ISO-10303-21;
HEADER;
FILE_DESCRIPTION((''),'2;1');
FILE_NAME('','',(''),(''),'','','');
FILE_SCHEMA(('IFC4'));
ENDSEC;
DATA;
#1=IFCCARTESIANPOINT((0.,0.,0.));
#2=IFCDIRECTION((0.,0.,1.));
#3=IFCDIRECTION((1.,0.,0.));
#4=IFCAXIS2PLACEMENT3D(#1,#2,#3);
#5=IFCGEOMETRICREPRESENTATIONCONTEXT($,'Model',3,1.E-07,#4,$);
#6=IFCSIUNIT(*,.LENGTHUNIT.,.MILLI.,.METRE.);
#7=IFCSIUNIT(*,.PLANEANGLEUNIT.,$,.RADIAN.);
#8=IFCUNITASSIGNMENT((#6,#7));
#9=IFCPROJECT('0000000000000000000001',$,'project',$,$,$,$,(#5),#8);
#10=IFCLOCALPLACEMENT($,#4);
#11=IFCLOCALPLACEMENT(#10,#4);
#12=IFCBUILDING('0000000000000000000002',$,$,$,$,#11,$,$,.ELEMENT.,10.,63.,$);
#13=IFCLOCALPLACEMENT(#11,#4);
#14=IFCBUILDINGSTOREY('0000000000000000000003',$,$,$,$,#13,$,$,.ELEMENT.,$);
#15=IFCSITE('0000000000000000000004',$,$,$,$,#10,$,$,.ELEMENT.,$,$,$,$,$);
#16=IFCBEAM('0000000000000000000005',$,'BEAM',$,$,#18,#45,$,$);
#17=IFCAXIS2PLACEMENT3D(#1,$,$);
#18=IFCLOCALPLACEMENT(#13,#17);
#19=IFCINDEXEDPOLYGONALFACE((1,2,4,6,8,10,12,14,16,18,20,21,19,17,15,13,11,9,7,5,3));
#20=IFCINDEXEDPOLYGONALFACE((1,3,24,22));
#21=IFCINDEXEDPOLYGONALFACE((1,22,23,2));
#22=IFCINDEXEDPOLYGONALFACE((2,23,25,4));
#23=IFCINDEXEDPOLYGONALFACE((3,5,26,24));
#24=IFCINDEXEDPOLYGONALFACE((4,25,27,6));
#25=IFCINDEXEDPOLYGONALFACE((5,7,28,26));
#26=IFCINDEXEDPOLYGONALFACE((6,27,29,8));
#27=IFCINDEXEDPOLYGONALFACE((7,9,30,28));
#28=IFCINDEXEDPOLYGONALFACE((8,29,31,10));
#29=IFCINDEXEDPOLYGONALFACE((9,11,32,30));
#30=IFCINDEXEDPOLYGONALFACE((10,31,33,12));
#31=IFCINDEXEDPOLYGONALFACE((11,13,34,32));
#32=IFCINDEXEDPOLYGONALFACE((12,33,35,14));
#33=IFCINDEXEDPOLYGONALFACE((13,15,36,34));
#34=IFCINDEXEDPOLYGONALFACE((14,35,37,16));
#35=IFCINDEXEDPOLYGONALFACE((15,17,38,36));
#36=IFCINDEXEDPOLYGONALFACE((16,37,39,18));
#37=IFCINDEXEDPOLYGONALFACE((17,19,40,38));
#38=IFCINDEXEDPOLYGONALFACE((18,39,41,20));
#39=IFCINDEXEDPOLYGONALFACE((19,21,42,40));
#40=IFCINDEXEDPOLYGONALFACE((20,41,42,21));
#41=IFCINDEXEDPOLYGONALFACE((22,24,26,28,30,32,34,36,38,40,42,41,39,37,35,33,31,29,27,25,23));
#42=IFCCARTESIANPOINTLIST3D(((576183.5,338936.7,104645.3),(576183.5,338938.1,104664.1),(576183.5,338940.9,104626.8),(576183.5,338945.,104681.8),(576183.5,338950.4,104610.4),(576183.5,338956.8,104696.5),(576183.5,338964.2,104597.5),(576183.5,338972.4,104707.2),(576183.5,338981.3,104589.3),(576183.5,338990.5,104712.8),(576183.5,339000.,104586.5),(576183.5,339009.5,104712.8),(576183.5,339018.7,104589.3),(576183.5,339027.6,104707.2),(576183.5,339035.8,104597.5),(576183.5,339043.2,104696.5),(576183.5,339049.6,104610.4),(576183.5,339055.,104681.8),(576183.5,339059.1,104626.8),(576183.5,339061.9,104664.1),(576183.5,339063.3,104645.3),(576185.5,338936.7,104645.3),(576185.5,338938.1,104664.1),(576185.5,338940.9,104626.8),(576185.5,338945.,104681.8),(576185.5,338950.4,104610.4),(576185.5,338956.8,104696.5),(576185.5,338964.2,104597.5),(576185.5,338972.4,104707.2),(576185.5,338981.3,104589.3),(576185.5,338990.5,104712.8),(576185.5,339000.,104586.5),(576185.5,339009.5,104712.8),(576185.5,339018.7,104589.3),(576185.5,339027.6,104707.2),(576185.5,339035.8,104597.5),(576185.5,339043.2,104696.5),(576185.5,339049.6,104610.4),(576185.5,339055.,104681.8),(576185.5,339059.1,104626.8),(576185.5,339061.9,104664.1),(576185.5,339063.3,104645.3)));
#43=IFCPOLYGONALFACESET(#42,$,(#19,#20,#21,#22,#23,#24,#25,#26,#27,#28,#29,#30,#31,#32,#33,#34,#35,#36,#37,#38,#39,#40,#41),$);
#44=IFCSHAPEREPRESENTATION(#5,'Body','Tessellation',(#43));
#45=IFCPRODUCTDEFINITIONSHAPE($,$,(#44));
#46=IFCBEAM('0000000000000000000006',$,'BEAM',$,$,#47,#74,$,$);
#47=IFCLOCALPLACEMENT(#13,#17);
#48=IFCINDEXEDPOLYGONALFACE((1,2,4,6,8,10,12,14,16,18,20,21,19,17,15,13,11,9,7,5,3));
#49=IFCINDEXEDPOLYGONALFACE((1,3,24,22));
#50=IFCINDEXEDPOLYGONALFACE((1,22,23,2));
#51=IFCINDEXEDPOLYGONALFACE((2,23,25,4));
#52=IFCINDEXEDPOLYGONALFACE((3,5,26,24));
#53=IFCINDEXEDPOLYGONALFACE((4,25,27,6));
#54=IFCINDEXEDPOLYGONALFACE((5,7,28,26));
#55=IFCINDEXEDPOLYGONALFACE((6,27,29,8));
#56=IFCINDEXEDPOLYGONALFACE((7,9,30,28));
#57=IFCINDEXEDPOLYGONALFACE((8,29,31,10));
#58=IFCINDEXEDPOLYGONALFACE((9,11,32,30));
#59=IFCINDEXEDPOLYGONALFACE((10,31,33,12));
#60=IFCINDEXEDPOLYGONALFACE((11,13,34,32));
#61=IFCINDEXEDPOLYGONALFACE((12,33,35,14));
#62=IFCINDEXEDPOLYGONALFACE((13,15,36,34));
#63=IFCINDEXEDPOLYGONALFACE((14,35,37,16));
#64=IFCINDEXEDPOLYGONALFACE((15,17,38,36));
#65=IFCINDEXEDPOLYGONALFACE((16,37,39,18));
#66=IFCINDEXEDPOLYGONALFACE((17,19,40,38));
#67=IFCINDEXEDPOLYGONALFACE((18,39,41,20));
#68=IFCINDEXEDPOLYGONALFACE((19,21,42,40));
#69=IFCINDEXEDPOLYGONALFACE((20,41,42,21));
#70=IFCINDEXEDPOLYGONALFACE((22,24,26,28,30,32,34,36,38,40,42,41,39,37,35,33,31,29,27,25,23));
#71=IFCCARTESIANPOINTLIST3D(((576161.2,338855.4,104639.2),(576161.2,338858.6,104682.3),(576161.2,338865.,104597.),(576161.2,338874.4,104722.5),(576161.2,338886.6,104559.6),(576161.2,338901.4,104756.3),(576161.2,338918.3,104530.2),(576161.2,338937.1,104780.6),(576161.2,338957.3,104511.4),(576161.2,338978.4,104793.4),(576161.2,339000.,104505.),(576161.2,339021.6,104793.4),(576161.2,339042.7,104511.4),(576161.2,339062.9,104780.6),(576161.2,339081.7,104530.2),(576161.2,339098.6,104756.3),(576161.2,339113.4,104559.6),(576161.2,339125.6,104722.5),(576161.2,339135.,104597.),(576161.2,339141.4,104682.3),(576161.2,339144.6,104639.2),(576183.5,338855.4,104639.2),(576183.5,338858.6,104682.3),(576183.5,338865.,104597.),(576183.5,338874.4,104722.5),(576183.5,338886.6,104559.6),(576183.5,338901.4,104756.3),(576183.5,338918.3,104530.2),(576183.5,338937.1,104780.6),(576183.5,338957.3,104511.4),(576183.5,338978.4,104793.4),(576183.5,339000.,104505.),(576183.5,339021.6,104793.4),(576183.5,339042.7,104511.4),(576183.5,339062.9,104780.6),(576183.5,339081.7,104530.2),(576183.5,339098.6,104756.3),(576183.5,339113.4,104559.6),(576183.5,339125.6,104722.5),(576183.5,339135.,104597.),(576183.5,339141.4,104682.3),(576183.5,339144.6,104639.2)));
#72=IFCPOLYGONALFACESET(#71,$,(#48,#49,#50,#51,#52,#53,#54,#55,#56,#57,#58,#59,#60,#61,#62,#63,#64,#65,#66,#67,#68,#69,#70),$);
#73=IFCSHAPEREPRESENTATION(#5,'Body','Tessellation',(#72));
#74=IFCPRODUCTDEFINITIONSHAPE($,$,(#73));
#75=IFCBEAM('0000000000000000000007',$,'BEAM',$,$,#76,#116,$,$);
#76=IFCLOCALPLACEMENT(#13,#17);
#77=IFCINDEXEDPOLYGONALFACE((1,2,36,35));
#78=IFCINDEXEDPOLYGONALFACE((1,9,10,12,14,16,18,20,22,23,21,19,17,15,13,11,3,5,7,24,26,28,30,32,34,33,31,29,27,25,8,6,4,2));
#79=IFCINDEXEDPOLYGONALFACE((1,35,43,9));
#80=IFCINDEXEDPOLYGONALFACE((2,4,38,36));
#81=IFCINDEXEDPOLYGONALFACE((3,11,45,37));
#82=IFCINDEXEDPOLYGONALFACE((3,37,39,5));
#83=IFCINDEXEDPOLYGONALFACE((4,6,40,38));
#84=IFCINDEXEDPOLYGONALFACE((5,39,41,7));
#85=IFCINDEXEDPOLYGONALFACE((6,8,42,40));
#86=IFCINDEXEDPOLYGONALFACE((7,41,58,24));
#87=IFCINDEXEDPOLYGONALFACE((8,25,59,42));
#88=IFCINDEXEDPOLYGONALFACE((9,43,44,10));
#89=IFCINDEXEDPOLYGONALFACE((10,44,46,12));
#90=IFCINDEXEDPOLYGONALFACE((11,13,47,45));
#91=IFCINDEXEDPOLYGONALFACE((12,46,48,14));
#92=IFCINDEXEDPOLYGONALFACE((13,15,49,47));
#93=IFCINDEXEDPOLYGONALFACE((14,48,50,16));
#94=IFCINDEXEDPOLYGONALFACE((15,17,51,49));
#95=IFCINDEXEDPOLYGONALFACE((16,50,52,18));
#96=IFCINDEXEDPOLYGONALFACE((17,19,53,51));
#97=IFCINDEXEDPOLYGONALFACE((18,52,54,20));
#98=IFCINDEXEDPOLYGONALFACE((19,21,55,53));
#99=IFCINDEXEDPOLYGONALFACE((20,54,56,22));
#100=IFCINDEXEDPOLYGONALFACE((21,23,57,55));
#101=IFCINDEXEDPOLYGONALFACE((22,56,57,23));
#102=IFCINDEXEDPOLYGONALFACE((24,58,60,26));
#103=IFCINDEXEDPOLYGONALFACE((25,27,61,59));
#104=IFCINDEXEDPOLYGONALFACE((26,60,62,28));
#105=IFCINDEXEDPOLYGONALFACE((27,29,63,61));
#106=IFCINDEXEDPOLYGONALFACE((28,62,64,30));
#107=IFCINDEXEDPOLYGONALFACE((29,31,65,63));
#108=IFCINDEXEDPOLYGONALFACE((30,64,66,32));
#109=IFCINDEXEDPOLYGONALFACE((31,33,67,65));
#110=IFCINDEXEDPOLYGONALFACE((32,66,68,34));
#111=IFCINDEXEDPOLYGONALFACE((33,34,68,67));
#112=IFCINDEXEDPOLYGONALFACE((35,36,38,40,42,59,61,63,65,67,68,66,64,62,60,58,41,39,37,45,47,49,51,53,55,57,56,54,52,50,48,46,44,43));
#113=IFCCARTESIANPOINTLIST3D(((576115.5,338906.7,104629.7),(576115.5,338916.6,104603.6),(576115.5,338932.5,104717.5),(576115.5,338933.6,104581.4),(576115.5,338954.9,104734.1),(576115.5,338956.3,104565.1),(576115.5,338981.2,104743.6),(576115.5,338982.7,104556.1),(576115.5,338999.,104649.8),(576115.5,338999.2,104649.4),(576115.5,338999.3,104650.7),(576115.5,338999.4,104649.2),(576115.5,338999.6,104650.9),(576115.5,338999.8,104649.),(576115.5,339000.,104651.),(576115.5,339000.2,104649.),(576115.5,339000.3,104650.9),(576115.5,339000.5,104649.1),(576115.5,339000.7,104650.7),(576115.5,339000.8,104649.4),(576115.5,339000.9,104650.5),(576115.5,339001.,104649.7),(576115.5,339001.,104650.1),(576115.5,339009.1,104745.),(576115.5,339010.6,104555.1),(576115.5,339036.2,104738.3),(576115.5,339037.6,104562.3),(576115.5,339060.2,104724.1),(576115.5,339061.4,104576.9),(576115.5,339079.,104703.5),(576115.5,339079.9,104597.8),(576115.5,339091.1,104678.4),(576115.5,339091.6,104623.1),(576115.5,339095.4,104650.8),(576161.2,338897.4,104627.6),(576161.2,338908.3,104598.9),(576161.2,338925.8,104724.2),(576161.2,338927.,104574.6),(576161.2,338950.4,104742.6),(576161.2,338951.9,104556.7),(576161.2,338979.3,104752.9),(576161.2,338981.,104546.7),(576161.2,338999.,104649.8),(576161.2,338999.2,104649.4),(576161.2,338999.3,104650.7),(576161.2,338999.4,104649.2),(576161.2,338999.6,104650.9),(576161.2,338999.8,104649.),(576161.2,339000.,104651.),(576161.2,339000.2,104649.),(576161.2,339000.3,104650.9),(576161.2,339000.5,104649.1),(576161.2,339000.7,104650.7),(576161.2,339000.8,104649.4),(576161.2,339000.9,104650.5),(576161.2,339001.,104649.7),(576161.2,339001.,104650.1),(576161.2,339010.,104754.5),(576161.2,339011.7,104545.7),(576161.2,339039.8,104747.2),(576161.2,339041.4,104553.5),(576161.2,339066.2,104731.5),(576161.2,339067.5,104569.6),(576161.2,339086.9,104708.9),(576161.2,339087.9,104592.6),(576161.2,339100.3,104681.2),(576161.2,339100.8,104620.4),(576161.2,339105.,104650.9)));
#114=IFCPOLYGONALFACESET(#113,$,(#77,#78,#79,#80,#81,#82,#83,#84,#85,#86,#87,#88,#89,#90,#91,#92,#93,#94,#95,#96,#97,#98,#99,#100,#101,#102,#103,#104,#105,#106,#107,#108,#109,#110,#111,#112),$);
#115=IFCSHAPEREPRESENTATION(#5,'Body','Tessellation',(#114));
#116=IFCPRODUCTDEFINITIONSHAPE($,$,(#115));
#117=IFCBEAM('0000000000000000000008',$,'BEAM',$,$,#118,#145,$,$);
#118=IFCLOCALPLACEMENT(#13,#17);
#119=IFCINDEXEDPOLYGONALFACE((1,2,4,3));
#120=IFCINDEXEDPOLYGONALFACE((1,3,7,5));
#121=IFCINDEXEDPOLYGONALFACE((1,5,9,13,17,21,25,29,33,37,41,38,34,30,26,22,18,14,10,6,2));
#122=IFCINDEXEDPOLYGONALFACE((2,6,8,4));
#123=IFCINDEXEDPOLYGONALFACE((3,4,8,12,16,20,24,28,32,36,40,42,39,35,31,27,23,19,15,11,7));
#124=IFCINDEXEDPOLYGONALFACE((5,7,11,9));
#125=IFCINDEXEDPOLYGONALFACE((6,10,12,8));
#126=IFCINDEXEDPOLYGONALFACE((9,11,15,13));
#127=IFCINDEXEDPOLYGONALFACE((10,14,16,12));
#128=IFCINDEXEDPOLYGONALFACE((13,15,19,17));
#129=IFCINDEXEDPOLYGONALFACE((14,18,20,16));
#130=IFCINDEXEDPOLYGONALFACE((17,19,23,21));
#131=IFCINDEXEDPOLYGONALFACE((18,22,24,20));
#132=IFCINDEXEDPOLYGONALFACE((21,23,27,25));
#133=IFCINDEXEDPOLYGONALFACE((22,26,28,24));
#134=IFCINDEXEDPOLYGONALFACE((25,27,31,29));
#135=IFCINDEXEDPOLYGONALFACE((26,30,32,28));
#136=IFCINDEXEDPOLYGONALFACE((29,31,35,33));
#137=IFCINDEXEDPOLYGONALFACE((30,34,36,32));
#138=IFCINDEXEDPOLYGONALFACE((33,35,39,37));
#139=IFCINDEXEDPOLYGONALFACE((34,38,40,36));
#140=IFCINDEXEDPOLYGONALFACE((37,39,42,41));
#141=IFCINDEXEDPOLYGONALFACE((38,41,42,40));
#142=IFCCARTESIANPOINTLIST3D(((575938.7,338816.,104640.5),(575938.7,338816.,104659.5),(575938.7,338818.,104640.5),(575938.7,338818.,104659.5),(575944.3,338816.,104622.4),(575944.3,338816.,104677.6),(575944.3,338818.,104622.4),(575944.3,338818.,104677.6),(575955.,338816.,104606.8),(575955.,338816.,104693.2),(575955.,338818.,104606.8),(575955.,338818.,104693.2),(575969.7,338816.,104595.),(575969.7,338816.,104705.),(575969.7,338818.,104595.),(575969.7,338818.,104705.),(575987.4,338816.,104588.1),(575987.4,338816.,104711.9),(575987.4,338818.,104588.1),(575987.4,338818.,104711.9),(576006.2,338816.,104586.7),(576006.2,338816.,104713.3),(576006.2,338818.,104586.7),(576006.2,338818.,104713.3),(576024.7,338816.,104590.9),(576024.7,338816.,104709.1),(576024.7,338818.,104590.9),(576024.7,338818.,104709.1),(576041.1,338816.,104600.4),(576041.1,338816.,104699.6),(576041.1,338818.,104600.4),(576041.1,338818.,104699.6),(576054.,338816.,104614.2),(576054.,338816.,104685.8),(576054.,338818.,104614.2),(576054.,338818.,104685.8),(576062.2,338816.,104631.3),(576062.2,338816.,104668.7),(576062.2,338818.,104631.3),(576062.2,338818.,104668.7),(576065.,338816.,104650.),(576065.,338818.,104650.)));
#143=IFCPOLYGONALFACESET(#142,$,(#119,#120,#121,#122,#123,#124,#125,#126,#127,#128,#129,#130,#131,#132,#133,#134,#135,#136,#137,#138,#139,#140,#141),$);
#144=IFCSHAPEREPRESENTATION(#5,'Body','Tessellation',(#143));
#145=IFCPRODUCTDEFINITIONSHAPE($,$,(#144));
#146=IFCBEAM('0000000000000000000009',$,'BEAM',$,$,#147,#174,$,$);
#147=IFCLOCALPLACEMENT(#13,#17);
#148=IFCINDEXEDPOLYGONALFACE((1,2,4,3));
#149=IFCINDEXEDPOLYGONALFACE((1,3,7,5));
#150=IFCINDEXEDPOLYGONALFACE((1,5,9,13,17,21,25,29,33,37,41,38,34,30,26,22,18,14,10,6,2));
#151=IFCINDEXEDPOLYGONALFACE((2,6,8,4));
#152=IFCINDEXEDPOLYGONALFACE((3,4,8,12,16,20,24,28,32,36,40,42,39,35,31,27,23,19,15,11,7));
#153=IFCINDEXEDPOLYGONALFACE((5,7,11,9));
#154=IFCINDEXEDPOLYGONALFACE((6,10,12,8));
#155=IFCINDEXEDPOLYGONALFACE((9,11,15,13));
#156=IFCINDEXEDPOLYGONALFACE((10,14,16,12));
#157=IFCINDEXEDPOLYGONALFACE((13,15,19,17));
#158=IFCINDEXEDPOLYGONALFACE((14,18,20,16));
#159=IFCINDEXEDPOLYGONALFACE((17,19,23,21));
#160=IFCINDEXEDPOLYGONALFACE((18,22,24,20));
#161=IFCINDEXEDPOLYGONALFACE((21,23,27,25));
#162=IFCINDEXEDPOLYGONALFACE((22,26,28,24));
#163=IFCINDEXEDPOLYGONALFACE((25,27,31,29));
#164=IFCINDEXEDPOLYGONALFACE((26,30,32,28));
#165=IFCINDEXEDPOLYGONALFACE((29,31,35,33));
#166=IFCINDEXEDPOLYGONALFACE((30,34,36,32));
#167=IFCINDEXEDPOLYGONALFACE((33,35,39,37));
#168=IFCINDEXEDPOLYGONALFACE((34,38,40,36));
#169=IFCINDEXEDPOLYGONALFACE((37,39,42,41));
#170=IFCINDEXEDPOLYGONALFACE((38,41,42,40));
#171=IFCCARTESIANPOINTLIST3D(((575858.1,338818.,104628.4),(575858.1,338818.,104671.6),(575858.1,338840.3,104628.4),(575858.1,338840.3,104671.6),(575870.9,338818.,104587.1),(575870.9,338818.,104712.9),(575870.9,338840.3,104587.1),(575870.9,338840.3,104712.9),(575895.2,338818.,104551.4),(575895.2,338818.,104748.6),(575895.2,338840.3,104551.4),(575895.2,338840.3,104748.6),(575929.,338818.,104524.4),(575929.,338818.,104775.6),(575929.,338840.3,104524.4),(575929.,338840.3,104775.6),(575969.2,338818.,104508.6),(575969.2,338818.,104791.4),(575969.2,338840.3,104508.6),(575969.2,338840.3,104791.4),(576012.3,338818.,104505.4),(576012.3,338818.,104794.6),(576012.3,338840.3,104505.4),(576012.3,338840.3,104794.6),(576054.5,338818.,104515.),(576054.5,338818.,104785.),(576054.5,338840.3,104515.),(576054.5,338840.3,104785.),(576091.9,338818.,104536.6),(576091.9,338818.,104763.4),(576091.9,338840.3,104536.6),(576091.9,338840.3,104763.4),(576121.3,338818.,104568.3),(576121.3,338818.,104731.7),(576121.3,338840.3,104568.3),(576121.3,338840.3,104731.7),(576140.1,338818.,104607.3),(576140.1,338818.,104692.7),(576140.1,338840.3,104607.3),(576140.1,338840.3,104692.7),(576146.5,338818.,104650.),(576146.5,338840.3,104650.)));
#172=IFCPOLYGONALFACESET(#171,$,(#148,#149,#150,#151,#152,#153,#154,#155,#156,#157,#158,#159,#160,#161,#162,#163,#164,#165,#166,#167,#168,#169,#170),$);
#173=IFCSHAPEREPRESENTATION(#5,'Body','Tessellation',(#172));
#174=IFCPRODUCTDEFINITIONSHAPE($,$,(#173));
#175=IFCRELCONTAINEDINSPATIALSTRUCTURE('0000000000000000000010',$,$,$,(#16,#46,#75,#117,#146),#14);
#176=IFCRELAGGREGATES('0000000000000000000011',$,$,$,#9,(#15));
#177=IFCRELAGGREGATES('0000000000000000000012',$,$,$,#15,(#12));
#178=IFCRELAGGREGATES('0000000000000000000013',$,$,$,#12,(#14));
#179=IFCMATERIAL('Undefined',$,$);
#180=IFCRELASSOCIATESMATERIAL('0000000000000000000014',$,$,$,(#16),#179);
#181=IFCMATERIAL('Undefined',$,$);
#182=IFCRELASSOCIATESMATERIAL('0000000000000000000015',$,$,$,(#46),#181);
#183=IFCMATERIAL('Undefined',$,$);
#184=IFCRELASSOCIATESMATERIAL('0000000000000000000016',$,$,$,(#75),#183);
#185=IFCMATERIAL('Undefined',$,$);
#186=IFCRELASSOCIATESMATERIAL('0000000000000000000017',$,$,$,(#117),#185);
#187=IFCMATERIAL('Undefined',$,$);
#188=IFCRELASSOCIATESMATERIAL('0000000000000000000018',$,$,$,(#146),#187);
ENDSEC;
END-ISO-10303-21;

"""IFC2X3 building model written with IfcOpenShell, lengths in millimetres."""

from ifc_helpers import new_model, entity, si_unit, frame, origin_with_axes, origin_2d_with_axis, place, context, project, spatial, circle, extrude, material, element, save


model = new_model("IFC2X3")

# Units and contexts
model_context = context("Model", 3, precision=1e-07, world=origin_with_axes())
ifc_project = project(units=[si_unit("LENGTHUNIT", "METRE", prefix="MILLI"), si_unit("PLANEANGLEUNIT", "RADIAN")], contexts=[model_context])

# Site, building, storey
site_placement = place(None, origin_with_axes())
site = spatial("IfcSite", under=ifc_project, at=site_placement, CompositionType="ELEMENT")
building_placement = place(site_placement, origin_with_axes())
building = spatial("IfcBuilding", under=site, at=building_placement, CompositionType="ELEMENT", ElevationOfRefHeight=10.0, ElevationOfTerrain=63.0)
storey_placement = place(building_placement, origin_with_axes())
storey = spatial("IfcBuildingStorey", under=building, at=storey_placement, CompositionType="ELEMENT")

# Beams
ifc_material_1 = material(Name="Undefined")
beam_1_placement = place(storey_placement, frame((576184.5, 339000.0, 104650.0), z_axis=(1.0, 0.0, 0.0), x_axis=(0.0, 1.0, 0.0)))
element("IfcBeam", 1, at=beam_1_placement, inside=storey, material=ifc_material_1, Name="BEAM", context=model_context, shape_type="SweptSolid", body=[
    extrude(circle(Radius=63.5, at=origin_2d_with_axis()), frame((0.0, 0.0, -1.0), z_axis=(0.0, 0.0, 1.0), x_axis=(0.0, -1.0, 0.0)), (0.0, 0.0, 1.0), 2.0),
])
ifc_material_2 = material(Name="Undefined")
beam_2_placement = place(storey_placement, frame((576172.3, 339000.0, 104650.0), z_axis=(1.0, 0.0, 0.0), x_axis=(0.0, 1.0, 0.0)))
element("IfcBeam", 2, at=beam_2_placement, inside=storey, material=ifc_material_2, Name="BEAM", context=model_context, shape_type="SweptSolid", body=[
    extrude(circle(Radius=145.0, at=origin_2d_with_axis()), frame((0.0, 0.0, -11.2), z_axis=(0.0, 0.0, 1.0), x_axis=(0.0, -1.0, 0.0)), (0.0, 0.0, 1.0), 22.3),
])
ifc_material_3 = material(Name="Undefined")
beam_3_placement = place(storey_placement, frame((576138.3, 339000.0, 104650.0), z_axis=(-1.0, 0.0, 0.0), x_axis=(0.0, 0.0, 1.0)))
element("IfcBeam", 3, at=beam_3_placement, inside=storey, material=ifc_material_3, Name="BEAM", context=model_context, shape_type="SweptSolid", body=[
    entity("IfcRevolvedAreaSolid", entity("IfcTrapeziumProfileDef", "AREA", None, entity("IfcAxis2Placement2D", entity("IfcCartesianPoint", [0.0, 53.0]), entity("IfcDirection", [0.0, 1.0])), 94.5, 104.0, 45.7, 0.0), entity("IfcAxis2Placement3D", entity("IfcCartesianPoint", [0.0, 0.0, 0.0]), entity("IfcDirection", [0.707107, 0.707107, 0.0]), entity("IfcDirection", [0.0, 0.0, 1.0])), entity("IfcAxis1Placement", entity("IfcCartesianPoint", [0.0, 0.0, 0.0]), entity("IfcDirection", [1.0, 0.0, 0.0])), 5.283185),
])
ifc_material_4 = material(Name="Undefined")
beam_4_placement = place(storey_placement, frame((576001.5, 338817.0, 104650.0), z_axis=(0.0, -1.0, 0.0), x_axis=(0.0, 0.0, 1.0)))
element("IfcBeam", 4, at=beam_4_placement, inside=storey, material=ifc_material_4, Name="BEAM", context=model_context, shape_type="SweptSolid", body=[
    extrude(circle(Radius=63.5, at=origin_2d_with_axis()), frame((0.0, 0.0, -1.0), z_axis=(0.0, 0.0, 1.0), x_axis=(0.0, -1.0, 0.0)), (0.0, 0.0, 1.0), 2.0),
])
ifc_material_5 = material(Name="Undefined")
beam_5_placement = place(storey_placement, frame((576001.5, 338829.1, 104650.0), z_axis=(0.0, -1.0, 0.0), x_axis=(0.0, 0.0, 1.0)))
element("IfcBeam", 5, at=beam_5_placement, inside=storey, material=ifc_material_5, Name="BEAM", context=model_context, shape_type="SweptSolid", body=[
    extrude(circle(Radius=145.0, at=origin_2d_with_axis()), frame((0.0, 0.0, -11.2), z_axis=(0.0, 0.0, 1.0), x_axis=(0.0, -1.0, 0.0)), (0.0, 0.0, 1.0), 22.3),
])

save(model, "model.ifc")
